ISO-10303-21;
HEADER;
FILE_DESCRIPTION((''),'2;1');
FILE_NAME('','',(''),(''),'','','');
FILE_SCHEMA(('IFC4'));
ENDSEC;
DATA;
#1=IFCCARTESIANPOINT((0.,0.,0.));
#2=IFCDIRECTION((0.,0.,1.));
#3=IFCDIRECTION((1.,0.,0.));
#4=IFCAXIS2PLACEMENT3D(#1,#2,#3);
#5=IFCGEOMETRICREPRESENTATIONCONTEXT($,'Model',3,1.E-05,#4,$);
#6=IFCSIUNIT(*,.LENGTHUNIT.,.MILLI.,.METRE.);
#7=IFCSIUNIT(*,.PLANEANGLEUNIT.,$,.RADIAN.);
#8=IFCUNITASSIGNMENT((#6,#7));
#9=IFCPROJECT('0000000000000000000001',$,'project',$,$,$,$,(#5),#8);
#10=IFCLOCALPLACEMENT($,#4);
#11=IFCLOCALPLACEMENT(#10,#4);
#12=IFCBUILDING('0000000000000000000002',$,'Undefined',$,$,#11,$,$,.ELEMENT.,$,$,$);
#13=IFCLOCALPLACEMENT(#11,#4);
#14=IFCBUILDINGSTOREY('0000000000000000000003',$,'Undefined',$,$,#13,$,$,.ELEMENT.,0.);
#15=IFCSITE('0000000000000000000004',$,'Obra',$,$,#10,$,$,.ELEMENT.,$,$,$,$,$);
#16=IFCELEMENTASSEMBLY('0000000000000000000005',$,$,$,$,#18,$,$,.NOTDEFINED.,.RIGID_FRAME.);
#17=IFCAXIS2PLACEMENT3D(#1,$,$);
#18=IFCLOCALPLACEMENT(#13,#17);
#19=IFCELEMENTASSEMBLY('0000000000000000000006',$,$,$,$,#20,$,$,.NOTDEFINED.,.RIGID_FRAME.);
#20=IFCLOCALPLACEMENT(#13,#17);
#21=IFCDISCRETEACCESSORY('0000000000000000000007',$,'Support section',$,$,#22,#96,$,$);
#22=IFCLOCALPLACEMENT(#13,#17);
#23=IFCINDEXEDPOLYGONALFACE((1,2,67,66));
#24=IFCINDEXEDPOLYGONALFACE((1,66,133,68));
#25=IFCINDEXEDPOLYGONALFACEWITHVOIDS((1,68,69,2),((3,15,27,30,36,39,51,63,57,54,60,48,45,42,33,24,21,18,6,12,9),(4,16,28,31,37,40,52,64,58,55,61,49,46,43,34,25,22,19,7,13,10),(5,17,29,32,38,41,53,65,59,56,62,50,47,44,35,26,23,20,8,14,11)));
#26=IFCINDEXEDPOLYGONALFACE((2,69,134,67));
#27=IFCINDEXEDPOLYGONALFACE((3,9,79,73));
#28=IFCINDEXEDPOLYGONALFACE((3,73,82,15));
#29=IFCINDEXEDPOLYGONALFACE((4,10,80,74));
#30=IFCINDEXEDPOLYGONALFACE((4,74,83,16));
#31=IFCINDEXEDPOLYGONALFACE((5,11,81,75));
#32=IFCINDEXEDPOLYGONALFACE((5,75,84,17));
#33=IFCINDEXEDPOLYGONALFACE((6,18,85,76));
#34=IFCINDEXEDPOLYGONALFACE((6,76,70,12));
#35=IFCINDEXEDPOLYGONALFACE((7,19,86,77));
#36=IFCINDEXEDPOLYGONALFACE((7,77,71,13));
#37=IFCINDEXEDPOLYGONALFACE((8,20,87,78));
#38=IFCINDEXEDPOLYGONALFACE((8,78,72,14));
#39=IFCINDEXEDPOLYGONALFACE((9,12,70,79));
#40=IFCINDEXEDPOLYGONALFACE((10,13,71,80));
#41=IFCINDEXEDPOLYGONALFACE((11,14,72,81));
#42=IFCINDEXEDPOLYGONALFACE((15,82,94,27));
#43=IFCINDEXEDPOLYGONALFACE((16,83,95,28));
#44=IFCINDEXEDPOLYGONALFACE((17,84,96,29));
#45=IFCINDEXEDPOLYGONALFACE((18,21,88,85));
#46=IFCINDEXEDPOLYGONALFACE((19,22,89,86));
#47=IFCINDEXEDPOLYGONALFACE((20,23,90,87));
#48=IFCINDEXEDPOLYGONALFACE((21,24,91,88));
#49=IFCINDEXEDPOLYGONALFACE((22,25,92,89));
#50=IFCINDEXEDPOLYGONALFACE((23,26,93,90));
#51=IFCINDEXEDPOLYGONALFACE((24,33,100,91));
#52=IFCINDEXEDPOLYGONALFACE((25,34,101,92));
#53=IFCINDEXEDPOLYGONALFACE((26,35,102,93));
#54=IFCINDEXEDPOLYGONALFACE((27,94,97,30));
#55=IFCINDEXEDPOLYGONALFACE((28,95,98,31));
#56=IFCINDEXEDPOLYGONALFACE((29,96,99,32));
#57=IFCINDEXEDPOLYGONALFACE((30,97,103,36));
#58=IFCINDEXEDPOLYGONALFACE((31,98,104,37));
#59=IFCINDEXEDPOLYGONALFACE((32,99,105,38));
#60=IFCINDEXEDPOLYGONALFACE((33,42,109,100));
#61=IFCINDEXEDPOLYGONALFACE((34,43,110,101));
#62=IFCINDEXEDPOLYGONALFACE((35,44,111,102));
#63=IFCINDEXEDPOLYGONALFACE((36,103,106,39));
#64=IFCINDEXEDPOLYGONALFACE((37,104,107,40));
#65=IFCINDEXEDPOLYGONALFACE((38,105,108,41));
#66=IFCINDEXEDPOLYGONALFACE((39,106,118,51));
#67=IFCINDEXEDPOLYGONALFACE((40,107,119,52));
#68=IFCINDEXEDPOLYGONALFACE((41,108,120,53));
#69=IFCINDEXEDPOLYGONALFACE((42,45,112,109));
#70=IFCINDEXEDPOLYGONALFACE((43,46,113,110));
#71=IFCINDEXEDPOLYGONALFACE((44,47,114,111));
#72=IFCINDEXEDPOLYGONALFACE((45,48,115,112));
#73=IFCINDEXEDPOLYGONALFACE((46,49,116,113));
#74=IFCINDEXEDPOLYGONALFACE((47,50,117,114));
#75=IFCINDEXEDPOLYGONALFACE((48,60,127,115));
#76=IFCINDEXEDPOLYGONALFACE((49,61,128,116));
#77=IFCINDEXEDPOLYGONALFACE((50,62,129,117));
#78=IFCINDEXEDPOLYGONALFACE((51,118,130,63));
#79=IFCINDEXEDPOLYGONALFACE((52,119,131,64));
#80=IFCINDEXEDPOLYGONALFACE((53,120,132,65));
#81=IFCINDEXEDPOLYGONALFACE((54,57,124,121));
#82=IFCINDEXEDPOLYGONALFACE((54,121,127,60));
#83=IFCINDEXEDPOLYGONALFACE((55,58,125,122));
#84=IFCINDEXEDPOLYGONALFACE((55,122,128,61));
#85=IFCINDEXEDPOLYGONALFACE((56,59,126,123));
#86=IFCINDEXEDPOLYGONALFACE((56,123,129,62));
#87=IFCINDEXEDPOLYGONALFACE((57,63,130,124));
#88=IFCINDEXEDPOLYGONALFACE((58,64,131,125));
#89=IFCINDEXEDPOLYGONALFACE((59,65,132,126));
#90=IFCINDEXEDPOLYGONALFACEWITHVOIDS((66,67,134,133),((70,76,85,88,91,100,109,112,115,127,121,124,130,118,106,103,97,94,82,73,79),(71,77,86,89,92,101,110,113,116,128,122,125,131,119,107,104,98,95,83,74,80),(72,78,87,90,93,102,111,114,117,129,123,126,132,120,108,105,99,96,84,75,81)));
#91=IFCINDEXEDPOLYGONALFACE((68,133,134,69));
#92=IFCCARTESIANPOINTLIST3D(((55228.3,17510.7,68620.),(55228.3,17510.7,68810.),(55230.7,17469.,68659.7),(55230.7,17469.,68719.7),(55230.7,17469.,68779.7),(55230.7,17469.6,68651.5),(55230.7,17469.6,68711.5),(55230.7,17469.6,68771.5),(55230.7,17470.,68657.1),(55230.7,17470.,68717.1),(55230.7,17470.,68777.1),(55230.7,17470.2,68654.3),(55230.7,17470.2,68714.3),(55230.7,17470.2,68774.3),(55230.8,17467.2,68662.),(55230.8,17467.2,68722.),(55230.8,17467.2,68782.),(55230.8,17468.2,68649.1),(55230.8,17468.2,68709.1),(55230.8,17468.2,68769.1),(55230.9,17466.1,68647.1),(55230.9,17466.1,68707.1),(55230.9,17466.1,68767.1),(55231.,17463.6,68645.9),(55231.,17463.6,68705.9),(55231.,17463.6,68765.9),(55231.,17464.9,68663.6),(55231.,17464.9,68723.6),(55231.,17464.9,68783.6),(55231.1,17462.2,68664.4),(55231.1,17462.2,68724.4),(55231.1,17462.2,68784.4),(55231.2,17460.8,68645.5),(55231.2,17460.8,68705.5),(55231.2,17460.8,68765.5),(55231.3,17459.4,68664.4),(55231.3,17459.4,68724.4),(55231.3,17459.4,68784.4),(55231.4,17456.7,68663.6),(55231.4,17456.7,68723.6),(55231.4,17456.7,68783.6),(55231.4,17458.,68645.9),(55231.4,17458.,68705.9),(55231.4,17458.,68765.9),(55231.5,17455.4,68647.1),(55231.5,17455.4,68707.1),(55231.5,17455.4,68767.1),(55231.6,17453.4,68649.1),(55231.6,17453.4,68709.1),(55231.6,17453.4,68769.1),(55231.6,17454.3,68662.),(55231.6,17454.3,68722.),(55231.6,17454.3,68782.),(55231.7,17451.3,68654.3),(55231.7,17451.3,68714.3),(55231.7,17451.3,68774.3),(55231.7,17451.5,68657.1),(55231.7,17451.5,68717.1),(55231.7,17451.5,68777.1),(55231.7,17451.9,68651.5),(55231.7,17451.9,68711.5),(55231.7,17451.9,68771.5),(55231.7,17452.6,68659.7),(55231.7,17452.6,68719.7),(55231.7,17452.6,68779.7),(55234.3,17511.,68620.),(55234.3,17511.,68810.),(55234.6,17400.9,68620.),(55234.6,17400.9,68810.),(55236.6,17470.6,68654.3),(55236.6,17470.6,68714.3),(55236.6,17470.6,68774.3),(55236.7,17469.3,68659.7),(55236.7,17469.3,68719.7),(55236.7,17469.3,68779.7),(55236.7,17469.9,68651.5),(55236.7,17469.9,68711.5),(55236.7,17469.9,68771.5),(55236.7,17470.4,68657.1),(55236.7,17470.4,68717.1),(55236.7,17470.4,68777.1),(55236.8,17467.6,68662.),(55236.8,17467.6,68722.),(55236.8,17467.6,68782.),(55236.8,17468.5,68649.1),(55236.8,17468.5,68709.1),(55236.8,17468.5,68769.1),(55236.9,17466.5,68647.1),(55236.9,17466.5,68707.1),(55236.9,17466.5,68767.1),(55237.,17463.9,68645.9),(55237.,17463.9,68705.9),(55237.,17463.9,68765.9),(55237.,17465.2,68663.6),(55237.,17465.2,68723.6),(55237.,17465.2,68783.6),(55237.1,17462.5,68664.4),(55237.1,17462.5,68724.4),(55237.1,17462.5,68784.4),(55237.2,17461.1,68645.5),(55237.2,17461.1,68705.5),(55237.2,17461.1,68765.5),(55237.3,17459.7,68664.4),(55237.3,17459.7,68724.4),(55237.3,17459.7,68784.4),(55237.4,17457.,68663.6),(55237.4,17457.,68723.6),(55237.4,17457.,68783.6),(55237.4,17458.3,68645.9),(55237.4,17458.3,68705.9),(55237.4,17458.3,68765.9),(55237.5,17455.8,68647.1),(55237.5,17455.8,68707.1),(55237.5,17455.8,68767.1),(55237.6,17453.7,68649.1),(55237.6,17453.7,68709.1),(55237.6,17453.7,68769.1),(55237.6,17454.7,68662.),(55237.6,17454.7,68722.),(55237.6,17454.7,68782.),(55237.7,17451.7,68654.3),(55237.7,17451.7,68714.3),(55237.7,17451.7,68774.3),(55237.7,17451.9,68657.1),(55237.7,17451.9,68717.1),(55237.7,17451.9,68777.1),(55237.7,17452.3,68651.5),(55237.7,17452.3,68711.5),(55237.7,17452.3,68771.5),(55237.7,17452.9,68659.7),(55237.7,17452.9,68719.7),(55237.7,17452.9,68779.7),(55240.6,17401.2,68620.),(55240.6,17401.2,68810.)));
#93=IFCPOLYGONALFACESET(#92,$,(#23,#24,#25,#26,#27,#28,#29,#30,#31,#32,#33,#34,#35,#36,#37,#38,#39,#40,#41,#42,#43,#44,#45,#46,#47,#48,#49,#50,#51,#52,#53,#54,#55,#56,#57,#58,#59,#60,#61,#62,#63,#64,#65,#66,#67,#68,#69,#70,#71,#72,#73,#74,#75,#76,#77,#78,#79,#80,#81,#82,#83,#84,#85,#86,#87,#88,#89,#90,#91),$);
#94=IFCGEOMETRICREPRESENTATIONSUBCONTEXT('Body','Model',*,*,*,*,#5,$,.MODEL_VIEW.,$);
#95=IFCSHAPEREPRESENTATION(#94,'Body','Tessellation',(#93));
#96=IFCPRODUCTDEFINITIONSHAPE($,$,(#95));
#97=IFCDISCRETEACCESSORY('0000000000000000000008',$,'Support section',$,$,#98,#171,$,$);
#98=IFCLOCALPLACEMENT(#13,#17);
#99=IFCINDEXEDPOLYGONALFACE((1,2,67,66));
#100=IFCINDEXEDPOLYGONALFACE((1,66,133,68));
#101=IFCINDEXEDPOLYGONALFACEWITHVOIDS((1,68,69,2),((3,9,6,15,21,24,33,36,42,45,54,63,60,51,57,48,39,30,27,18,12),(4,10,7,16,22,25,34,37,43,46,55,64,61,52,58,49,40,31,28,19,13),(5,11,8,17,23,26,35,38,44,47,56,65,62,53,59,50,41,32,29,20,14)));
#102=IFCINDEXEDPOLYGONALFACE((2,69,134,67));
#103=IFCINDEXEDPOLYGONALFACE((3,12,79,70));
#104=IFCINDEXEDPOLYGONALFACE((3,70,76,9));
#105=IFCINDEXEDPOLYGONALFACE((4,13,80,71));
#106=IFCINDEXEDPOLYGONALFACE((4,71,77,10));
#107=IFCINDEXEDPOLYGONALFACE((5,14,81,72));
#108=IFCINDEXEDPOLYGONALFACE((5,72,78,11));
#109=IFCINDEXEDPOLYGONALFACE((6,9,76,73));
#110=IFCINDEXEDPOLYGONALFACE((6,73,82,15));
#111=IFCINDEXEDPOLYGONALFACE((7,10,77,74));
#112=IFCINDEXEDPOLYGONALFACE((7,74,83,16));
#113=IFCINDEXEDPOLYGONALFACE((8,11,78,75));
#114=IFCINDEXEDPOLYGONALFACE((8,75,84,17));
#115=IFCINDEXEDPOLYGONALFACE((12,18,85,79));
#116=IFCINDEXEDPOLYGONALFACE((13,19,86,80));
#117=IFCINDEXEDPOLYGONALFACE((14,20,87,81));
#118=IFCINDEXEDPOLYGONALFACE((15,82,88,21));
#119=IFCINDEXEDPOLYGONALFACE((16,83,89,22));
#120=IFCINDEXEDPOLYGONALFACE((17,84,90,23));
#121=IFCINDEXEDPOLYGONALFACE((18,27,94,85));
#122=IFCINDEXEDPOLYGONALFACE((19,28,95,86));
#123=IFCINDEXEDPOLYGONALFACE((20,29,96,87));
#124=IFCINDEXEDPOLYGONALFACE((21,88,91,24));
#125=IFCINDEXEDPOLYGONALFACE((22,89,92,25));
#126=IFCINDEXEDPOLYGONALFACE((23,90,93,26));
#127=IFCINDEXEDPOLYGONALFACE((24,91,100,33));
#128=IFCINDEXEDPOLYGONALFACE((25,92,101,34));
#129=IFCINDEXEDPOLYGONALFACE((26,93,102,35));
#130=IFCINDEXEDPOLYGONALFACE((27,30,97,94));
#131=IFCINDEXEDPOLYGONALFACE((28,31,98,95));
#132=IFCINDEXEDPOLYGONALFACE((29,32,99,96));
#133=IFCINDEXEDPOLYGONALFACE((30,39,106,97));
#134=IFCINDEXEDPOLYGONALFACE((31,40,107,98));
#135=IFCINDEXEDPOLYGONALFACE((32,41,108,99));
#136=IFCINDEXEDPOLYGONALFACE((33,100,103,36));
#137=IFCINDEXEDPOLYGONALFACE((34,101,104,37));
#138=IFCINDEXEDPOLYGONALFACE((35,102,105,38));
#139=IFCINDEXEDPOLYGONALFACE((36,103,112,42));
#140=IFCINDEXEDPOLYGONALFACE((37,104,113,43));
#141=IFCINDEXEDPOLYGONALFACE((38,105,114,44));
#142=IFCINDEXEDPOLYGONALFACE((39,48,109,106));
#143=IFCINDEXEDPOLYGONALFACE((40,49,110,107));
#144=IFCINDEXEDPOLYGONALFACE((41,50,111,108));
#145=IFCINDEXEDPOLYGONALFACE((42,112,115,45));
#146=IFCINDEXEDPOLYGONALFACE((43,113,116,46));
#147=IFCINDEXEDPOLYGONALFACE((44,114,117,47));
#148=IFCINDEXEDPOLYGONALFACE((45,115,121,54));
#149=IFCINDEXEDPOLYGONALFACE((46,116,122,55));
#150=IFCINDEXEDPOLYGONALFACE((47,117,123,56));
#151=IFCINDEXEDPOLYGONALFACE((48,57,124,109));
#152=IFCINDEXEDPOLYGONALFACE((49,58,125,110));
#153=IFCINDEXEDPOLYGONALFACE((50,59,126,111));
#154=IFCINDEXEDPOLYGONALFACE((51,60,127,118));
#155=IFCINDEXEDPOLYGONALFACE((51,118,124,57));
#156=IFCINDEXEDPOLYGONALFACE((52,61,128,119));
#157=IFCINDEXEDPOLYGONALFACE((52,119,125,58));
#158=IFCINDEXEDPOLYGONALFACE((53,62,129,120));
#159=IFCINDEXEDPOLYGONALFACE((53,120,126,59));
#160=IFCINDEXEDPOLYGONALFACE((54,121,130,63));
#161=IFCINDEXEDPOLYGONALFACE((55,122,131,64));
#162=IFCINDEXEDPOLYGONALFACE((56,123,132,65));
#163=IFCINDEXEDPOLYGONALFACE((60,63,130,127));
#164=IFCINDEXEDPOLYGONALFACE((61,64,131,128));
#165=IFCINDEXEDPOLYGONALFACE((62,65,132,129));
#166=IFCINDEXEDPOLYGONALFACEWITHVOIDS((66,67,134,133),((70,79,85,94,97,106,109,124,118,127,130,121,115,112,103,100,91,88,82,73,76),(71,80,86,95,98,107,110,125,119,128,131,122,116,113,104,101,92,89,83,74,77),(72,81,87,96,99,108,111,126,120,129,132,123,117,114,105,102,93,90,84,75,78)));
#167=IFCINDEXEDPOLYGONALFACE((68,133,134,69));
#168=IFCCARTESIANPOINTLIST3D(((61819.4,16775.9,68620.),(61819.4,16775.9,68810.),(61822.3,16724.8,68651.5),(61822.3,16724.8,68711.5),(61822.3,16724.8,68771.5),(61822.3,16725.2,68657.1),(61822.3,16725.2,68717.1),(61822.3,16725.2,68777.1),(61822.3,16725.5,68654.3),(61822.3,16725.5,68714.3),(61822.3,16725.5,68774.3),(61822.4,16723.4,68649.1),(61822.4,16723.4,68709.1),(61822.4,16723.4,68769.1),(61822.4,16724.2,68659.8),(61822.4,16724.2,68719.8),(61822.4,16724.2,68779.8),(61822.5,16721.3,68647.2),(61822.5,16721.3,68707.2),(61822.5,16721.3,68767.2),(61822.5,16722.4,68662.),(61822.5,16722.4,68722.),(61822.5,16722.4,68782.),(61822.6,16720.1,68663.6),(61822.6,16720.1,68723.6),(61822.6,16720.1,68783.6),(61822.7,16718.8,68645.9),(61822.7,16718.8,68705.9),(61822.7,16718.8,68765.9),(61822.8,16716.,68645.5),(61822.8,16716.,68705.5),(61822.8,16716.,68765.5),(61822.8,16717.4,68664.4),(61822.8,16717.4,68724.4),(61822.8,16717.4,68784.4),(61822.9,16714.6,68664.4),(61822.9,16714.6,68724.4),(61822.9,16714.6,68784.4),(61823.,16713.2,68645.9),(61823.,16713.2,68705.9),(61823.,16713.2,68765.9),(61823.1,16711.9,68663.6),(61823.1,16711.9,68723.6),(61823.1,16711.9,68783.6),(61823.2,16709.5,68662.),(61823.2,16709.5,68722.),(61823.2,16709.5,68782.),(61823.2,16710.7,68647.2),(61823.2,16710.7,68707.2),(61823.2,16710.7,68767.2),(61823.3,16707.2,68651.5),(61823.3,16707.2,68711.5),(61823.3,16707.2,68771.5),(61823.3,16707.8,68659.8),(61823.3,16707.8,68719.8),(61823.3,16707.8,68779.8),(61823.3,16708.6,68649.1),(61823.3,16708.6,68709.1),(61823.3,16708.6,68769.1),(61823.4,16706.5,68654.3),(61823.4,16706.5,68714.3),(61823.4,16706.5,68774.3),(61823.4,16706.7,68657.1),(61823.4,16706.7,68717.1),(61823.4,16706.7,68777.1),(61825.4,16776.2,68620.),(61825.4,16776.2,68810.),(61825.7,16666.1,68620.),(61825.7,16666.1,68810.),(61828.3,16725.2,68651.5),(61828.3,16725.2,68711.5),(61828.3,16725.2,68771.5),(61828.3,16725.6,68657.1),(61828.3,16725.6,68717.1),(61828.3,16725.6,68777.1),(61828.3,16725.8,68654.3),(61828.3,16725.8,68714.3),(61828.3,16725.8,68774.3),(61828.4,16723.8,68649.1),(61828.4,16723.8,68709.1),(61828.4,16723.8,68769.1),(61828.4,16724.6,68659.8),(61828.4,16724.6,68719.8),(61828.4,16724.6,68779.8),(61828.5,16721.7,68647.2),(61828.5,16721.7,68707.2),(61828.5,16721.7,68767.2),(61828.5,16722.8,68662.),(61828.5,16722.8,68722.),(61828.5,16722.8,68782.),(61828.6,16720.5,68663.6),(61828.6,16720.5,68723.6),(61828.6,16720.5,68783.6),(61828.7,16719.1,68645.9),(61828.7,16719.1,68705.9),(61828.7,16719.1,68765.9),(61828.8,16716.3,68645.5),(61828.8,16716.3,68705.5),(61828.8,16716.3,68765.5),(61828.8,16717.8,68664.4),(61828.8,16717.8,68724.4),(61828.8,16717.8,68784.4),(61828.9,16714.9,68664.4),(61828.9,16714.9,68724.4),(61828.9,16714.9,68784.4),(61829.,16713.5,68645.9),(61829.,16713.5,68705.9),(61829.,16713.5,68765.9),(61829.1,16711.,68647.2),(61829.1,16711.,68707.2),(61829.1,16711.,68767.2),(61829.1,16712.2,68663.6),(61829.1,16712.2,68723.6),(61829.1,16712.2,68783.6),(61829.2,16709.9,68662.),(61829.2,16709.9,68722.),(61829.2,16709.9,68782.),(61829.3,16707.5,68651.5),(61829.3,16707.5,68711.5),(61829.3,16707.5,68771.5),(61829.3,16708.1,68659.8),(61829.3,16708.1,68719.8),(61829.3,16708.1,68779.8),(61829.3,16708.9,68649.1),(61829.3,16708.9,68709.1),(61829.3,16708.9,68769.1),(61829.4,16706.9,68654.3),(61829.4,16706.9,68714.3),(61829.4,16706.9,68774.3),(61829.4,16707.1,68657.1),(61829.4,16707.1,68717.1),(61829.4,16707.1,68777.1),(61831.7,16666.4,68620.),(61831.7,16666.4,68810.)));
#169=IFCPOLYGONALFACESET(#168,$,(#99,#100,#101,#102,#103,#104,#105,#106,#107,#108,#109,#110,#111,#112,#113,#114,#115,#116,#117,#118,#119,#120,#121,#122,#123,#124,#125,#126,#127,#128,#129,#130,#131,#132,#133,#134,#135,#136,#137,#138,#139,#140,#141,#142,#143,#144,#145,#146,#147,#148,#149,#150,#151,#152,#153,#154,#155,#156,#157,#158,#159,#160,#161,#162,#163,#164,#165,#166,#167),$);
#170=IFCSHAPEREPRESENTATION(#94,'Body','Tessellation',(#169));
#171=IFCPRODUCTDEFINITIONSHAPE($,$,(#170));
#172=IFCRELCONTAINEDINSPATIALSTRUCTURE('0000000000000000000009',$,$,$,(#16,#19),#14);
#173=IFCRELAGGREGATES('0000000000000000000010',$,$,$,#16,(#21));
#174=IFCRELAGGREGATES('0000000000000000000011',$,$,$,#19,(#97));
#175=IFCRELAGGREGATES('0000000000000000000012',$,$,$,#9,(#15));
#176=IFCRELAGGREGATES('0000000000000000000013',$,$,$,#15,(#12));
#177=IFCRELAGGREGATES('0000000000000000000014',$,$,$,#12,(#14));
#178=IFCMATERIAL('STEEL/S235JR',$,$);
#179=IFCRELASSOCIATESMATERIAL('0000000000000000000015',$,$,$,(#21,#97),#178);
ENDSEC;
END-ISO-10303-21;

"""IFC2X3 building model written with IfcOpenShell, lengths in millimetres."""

from ifc_helpers import new_model, si_unit, frame, origin_with_axes, origin_2d_with_axis, place, context, subcontext, project, spatial, rectangle, circle, extrude, source, transform, mapped, material, element, aggregate, save


model = new_model("IFC2X3")

# Units and contexts
model_context = context("Model", 3, precision=1e-05, world=origin_with_axes())
body_context = subcontext(model_context, "Body", "Model", "MODEL_VIEW")
ifc_project = project(units=[si_unit("LENGTHUNIT", "METRE", prefix="MILLI"), si_unit("PLANEANGLEUNIT", "RADIAN")], contexts=[model_context])

# Site, building, storey
site_placement = place(None, origin_with_axes())
site = spatial("IfcSite", under=ifc_project, at=site_placement, Name="Obra", CompositionType="ELEMENT")
building_placement = place(site_placement, origin_with_axes())
building = spatial("IfcBuilding", under=site, at=building_placement, Name="Undefined", CompositionType="ELEMENT")
storey_placement = place(building_placement, origin_with_axes())
storey = spatial("IfcBuildingStorey", under=building, at=storey_placement, Name="Undefined", CompositionType="ELEMENT", Elevation=0.0)

# Element assemblies
ifc_material_1 = material(Name="STEEL/S235JR")
assembly_1_placement = place(storey_placement, origin_with_axes())
assembly_1 = element("IfcElementAssembly", 1, at=assembly_1_placement, inside=storey, AssemblyPlace="NOTDEFINED", PredefinedType="RIGID_FRAME")
assembly_2_placement = place(storey_placement, origin_with_axes())
assembly_2 = element("IfcElementAssembly", 2, at=assembly_2_placement, inside=storey, AssemblyPlace="NOTDEFINED", PredefinedType="RIGID_FRAME")

# Discrete accessories, openings
shared_shape_1 = source(origin_with_axes(), body_context, "Body", "SweptSolid", [
    extrude(circle(Radius=9.5, at=origin_2d_with_axis()), frame((0.0, -9.2, 0.0), z_axis=(0.0, 1.0, 0.0), x_axis=(1.0, 0.0, 0.0)), (0.0, 0.0, 1.0), 6.2),
])
discrete_accessory_1_placement = place(assembly_1_placement, frame((55234.5, 17456.0, 68620.0), z_axis=(0.0, 0.0, 1.0), x_axis=(0.057107, -0.998368, 0.0)))
discrete_accessory_1 = element("IfcDiscreteAccessory", 3, at=discrete_accessory_1_placement, material=ifc_material_1, Name="Support section", context=body_context, shape_type="SweptSolid", body=[
    extrude(rectangle(XDim=6.0, YDim=110.0, at=origin_2d_with_axis()), frame((0.0, 0.0, 190.0), z_axis=(0.0, 0.0, -1.0), x_axis=(0.0, 1.0, 0.0)), (0.0, 0.0, 1.0), 190.0),
])
opening_1_placement = place(assembly_1_placement, frame((55231.0, 17410.7, 68835.0), z_axis=(-0.057107, 0.998368, 0.0), x_axis=(0.0, 0.0, -1.0)))
element("IfcOpeningElement", 4, at=opening_1_placement, cuts=discrete_accessory_1, ObjectType="Opening", context=body_context, shape_type="MappedRepresentation", body=[
    mapped(shared_shape_1, transform((60.0, 0.0, 50.0))),
    mapped(shared_shape_1, transform((120.0, 0.0, 50.0))),
    mapped(shared_shape_1, transform((180.0, 0.0, 50.0))),
])
aggregate(assembly_1, [discrete_accessory_1])
discrete_accessory_2_placement = place(assembly_2_placement, frame((61825.6, 16721.2, 68620.0), z_axis=(0.0, 0.0, 1.0), x_axis=(-0.057107, 0.998368, 0.0)))
discrete_accessory_2 = element("IfcDiscreteAccessory", 5, at=discrete_accessory_2_placement, material=ifc_material_1, Name="Support section", context=body_context, shape_type="SweptSolid", body=[
    extrude(rectangle(XDim=6.0, YDim=110.0, at=origin_2d_with_axis()), frame((0.0, 0.0, 190.0), z_axis=(0.0, 0.0, -1.0), x_axis=(0.0, 1.0, 0.0)), (0.0, 0.0, 1.0), 190.0),
])
opening_2_placement = place(assembly_2_placement, frame((61829.1, 16766.4, 68835.0), z_axis=(0.057107, -0.998368, 0.0), x_axis=(0.0, 0.0, -1.0)))
element("IfcOpeningElement", 6, at=opening_2_placement, cuts=discrete_accessory_2, ObjectType="Opening", context=body_context, shape_type="MappedRepresentation", body=[
    mapped(shared_shape_1, transform((60.0, 0.0, 50.0))),
    mapped(shared_shape_1, transform((120.0, 0.0, 50.0))),
    mapped(shared_shape_1, transform((180.0, 0.0, 50.0))),
])
aggregate(assembly_2, [discrete_accessory_2])

save(model, "model.ifc")
